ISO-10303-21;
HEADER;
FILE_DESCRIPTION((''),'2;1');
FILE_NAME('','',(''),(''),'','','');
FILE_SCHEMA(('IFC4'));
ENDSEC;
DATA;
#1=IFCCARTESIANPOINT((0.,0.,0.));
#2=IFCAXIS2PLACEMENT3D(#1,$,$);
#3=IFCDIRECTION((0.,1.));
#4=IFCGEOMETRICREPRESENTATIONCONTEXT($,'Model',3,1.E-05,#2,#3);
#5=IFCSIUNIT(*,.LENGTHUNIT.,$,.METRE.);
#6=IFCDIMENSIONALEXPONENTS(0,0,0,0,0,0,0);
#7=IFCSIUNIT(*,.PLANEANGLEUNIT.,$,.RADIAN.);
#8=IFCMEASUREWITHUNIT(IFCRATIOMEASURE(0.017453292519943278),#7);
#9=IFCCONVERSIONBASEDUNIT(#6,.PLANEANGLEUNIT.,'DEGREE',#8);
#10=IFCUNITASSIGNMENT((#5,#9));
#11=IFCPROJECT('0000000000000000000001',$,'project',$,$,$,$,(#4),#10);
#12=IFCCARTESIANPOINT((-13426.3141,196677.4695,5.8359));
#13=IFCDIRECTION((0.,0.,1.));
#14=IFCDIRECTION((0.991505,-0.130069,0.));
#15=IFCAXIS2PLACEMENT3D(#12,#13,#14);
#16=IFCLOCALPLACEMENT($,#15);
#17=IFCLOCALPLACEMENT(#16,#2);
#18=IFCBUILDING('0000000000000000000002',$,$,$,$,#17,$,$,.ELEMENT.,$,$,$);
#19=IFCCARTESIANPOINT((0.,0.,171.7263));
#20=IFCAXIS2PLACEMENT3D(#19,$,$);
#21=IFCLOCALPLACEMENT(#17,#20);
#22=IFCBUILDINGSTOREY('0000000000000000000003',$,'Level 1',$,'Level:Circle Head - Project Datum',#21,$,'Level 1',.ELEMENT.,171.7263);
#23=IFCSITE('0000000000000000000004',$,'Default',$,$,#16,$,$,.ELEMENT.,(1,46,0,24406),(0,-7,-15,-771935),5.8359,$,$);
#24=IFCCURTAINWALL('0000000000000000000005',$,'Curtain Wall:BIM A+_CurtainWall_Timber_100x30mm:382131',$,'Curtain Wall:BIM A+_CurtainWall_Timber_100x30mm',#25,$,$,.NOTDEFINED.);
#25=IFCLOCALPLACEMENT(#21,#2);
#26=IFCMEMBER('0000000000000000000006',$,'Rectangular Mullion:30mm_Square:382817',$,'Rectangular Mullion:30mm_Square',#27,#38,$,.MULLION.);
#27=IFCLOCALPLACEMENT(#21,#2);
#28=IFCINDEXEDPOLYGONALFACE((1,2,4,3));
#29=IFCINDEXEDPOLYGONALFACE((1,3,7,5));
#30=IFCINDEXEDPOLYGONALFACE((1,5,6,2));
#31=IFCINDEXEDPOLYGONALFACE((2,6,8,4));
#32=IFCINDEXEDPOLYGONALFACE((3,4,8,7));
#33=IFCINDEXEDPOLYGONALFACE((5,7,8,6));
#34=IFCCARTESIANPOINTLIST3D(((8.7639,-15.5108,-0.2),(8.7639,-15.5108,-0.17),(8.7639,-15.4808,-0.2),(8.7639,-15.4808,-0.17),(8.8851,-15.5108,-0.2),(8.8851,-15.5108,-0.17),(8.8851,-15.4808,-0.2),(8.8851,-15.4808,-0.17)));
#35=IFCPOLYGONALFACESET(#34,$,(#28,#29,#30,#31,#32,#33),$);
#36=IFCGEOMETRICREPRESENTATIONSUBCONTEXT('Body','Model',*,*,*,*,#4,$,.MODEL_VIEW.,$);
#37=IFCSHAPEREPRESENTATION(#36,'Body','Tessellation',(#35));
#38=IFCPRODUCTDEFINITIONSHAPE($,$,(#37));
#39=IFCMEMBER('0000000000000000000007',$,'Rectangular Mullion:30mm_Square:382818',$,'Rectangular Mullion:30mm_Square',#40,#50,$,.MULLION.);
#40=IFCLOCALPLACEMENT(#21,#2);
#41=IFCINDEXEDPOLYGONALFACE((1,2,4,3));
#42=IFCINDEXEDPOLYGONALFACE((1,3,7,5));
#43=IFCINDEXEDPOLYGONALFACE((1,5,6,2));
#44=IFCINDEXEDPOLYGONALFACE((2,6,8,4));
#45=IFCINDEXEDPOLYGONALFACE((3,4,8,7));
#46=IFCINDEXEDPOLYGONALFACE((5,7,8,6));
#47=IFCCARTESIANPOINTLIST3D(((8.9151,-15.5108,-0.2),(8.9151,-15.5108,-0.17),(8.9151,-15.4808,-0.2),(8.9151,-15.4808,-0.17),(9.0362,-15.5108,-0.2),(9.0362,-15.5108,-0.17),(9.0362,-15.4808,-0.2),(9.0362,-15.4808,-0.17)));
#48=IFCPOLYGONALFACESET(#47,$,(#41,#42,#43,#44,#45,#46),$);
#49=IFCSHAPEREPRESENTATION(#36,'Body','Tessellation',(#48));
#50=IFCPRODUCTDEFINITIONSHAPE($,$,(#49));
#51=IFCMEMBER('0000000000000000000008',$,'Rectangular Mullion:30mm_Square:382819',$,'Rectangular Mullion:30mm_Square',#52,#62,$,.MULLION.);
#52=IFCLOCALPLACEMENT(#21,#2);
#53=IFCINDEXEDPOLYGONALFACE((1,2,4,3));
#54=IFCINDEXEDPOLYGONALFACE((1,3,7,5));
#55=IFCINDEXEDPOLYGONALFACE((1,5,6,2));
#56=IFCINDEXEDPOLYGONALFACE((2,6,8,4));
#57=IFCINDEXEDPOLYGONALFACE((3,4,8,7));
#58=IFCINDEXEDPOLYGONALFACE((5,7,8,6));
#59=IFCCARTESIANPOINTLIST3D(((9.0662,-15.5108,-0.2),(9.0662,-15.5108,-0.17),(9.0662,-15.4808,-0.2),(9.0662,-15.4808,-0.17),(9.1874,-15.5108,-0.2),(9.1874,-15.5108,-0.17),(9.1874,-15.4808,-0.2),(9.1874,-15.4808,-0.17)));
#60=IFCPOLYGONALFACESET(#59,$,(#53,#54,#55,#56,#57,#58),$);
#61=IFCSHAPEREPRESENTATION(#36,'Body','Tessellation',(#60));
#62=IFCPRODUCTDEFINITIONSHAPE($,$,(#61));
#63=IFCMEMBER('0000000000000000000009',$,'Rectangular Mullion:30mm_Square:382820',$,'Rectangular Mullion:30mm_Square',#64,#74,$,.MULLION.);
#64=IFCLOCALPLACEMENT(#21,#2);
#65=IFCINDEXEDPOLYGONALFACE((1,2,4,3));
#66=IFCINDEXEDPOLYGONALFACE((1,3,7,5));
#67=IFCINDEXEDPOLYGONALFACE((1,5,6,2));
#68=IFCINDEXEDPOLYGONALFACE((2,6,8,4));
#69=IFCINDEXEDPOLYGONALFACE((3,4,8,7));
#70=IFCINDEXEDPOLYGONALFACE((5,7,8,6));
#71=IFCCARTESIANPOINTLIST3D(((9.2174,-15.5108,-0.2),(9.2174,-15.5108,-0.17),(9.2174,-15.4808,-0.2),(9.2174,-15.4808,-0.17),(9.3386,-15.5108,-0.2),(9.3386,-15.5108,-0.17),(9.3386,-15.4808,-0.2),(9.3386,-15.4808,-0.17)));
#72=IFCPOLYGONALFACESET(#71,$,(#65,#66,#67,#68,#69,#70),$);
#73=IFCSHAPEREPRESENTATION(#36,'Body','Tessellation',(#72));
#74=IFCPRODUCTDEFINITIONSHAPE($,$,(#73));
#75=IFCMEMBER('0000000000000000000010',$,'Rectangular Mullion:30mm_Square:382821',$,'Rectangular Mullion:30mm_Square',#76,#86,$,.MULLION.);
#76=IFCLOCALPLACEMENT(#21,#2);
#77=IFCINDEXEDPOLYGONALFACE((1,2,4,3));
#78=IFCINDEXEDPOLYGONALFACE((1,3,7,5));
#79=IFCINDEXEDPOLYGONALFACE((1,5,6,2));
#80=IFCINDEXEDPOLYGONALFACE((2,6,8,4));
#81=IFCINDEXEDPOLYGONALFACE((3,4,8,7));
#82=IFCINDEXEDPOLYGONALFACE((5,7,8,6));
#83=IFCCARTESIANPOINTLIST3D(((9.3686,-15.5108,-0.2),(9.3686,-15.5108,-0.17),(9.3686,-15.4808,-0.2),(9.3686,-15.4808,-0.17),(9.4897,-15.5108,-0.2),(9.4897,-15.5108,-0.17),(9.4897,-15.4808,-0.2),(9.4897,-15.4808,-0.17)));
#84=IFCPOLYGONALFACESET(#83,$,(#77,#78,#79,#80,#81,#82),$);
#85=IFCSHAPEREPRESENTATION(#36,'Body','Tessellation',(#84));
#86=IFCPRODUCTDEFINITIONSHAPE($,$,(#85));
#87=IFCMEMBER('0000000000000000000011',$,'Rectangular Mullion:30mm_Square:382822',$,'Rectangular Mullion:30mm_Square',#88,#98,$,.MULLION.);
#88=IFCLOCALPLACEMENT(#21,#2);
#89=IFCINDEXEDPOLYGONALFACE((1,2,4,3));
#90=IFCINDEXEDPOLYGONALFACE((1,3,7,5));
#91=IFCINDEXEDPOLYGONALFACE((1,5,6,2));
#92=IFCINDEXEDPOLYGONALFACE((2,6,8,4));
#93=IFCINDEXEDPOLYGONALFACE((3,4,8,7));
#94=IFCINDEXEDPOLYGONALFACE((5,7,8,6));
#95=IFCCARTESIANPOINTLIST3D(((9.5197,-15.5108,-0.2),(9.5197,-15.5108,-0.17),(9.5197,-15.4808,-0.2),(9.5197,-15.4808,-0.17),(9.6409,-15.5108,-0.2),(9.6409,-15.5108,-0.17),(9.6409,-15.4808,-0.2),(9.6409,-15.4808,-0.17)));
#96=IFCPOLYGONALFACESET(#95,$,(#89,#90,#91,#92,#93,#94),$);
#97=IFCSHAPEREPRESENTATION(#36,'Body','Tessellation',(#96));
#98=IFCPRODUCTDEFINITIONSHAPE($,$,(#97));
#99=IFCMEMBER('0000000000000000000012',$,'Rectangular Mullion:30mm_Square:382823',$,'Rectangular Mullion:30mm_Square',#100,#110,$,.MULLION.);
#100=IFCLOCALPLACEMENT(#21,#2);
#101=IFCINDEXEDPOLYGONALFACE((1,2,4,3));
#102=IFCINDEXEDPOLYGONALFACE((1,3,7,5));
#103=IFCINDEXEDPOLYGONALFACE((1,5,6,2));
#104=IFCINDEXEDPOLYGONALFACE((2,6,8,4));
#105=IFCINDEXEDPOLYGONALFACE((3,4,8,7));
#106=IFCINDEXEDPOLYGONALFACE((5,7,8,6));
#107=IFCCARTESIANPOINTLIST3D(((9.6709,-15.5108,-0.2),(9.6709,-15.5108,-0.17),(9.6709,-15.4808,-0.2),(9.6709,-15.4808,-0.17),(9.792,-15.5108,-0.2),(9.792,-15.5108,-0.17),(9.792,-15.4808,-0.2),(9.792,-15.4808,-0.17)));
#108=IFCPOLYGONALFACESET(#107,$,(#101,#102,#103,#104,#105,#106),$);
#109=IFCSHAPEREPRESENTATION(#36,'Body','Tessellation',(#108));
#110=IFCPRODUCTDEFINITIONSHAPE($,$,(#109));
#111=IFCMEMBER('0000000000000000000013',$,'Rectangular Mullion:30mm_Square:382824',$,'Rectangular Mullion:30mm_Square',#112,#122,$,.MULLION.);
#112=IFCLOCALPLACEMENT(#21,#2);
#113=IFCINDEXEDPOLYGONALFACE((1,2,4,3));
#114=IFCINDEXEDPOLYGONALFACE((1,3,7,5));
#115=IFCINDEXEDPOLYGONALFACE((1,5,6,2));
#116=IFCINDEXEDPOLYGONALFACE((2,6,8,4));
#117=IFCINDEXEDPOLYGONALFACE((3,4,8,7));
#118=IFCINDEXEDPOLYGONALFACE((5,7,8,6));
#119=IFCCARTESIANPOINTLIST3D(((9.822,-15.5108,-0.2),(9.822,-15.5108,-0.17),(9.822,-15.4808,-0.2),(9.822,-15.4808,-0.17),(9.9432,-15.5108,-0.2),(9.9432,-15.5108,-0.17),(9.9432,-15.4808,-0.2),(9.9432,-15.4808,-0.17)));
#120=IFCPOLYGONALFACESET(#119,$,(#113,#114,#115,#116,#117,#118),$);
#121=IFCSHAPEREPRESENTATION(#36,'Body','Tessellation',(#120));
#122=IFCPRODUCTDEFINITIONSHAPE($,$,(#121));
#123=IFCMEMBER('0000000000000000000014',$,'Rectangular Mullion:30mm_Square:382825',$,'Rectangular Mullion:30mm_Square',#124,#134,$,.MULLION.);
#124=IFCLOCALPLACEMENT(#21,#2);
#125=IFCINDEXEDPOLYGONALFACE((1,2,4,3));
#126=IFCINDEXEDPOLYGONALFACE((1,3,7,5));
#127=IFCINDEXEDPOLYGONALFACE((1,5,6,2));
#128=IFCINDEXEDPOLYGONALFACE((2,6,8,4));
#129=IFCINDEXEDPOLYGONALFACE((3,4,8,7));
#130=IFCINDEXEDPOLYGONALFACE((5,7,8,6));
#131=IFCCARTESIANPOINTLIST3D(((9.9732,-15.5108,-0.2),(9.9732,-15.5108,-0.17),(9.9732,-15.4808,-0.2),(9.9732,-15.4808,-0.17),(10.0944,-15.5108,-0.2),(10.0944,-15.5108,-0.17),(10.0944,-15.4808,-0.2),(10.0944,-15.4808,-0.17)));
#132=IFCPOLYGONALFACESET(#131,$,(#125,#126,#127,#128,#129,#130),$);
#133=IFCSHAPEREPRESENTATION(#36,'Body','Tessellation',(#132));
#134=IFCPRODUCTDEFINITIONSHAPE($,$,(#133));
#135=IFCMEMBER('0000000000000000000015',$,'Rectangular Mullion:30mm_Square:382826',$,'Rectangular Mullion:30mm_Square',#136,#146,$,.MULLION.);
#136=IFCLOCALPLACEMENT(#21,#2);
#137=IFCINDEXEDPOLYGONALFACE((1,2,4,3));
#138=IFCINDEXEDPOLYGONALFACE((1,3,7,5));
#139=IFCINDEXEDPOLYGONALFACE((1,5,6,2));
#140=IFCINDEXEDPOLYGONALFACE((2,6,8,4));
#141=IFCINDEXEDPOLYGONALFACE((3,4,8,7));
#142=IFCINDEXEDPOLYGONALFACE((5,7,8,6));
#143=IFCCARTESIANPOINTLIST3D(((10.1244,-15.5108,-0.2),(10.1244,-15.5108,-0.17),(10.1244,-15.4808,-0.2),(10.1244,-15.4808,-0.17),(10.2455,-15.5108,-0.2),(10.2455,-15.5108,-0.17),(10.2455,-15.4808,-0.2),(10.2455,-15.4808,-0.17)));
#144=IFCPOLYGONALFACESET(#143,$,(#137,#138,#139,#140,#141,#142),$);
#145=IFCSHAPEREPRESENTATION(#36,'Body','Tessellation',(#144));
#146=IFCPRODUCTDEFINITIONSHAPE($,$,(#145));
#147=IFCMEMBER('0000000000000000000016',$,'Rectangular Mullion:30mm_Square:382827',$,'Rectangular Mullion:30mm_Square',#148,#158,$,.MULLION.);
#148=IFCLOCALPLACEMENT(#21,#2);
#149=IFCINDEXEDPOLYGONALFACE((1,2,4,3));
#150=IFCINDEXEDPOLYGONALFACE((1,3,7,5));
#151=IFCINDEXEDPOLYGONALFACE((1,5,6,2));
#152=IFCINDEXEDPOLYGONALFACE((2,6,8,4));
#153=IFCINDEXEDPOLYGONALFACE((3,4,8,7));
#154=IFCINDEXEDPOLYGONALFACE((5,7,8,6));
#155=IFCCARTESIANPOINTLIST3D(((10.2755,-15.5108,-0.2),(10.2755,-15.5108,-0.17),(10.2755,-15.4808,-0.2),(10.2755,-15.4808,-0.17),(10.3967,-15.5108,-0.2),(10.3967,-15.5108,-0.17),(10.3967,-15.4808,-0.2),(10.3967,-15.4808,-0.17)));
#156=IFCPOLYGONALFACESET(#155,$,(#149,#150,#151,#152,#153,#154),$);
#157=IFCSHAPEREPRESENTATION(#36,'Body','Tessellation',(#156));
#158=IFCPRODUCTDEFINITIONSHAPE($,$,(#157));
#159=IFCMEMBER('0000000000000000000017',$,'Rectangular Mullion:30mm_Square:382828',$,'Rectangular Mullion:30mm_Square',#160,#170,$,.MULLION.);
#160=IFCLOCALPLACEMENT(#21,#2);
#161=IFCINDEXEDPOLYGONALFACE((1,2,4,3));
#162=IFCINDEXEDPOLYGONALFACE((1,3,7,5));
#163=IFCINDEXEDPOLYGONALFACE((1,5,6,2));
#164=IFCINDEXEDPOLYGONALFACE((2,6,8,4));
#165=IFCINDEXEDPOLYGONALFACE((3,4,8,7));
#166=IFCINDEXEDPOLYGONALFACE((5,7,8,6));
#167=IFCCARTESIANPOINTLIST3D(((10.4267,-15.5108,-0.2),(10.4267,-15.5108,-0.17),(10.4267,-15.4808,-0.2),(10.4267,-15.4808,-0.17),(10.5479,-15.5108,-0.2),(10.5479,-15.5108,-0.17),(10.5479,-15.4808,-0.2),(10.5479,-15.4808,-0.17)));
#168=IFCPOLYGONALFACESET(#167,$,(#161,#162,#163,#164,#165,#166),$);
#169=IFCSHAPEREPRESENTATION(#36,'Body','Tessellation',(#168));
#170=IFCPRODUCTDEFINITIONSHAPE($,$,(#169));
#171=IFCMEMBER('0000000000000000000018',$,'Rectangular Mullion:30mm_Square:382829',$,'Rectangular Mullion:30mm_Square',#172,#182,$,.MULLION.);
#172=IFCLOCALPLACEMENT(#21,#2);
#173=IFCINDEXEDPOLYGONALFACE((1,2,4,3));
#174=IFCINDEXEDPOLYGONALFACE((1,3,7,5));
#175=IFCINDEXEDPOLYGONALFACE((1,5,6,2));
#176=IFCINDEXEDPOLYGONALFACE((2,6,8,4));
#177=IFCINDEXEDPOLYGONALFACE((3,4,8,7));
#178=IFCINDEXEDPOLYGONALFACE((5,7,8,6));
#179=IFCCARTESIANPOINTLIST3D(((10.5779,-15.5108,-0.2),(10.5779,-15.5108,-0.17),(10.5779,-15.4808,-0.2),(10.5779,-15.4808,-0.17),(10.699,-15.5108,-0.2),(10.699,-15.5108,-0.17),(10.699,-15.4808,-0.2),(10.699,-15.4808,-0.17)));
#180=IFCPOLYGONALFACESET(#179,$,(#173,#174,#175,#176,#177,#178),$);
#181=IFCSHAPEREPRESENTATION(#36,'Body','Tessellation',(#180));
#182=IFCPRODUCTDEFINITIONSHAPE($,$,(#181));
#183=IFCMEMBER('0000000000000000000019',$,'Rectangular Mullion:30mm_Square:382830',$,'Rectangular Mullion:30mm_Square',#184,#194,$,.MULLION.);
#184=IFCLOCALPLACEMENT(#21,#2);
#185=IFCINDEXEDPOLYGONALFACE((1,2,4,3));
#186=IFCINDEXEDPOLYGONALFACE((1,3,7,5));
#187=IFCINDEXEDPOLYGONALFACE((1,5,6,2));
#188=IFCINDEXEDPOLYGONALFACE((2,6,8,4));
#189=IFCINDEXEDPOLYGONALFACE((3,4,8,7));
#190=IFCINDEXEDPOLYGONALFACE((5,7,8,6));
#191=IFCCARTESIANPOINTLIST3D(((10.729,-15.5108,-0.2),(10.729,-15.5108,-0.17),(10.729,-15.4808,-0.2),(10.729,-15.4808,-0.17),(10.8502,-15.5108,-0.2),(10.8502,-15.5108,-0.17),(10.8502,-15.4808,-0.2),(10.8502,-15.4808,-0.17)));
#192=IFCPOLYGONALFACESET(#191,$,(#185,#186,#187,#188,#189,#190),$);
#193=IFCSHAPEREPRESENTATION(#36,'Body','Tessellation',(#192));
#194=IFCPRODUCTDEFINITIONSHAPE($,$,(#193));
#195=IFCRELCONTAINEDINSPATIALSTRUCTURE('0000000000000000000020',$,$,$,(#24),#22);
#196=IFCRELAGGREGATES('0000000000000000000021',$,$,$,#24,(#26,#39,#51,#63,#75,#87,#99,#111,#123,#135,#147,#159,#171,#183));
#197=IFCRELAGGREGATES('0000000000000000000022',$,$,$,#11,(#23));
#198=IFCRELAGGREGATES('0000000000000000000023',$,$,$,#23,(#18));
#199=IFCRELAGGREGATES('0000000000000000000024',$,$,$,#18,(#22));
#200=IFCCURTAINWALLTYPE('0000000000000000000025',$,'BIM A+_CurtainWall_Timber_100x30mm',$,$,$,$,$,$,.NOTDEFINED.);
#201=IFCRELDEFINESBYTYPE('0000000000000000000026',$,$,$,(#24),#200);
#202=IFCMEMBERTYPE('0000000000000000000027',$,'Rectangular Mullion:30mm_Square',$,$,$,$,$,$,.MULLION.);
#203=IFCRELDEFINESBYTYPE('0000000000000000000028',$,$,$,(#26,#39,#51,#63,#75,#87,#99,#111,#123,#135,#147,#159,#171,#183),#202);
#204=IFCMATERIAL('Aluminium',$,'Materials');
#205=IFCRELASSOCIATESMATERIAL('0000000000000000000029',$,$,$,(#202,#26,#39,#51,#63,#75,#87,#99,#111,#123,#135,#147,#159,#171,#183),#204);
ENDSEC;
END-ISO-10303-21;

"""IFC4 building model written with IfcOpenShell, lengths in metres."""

from ifc_helpers import new_model, entity, si_unit, converted_unit, direction, frame, origin, place, context, subcontext, project, spatial, indexed_curve, outline, extrude, source, transform, mapped, material, type_object, type_shapes, element, aggregate, save


model = new_model("IFC4")

# Units and contexts
model_context = context("Model", 3, precision=1e-05, world=origin(), true_north=direction((0.0, 1.0)))
body_context = subcontext(model_context, "Body", "Model", "MODEL_VIEW")
ifc_project = project(units=[si_unit("LENGTHUNIT", "METRE"), converted_unit("PLANEANGLEUNIT", "DEGREE", entity("IfcRatioMeasure", 0.017453292519943278), si_unit("PLANEANGLEUNIT", "RADIAN"), dimensions=[0, 0, 0, 0, 0, 0, 0])], contexts=[model_context])

# Site, building, storey
site_placement = place(None, frame((-13426.3141, 196677.4695, 5.8359), z_axis=(0.0, 0.0, 1.0), x_axis=(0.991505, -0.130069, 0.0)))
site = spatial("IfcSite", under=ifc_project, at=site_placement, Name="Default", CompositionType="ELEMENT", RefLatitude=(1, 46, 0, 24406), RefLongitude=(0, -7, -15, -771935), RefElevation=5.8359)
building_placement = place(site_placement, origin())
building = spatial("IfcBuilding", under=site, at=building_placement, CompositionType="ELEMENT")
storey_placement = place(building_placement, frame((0.0, 0.0, 171.7263)))
storey = spatial("IfcBuildingStorey", under=building, at=storey_placement, Name="Level 1", ObjectType="Level:Circle Head - Project Datum", LongName="Level 1", CompositionType="ELEMENT", Elevation=171.7263)

# Curtain wall, members
curtain_wall_type = type_object("IfcCurtainWallType", Name="BIM A+_CurtainWall_Timber_100x30mm", PredefinedType="NOTDEFINED")
curtain_wall_placement = place(storey_placement, frame((0.0, 0.0, -171.7263)))
curtain_wall = element("IfcCurtainWall", 1, at=curtain_wall_placement, inside=storey, type_object=curtain_wall_type, Name="Curtain Wall:BIM A+_CurtainWall_Timber_100x30mm:382131", ObjectType="Curtain Wall:BIM A+_CurtainWall_Timber_100x30mm", PredefinedType="NOTDEFINED")
ifc_material_1 = material(Name="Aluminium", Category="Materials")
member_type = type_object("IfcMemberType", Name="Rectangular Mullion:30mm_Square", PredefinedType="MULLION", material=ifc_material_1)
shared_shape_1 = source(origin(), body_context, "Body", "SweptSolid", [
    extrude(outline(indexed_curve([(-0.015, -0.015), (0.015, -0.015), (0.015, 0.015), (-0.015, 0.015), (-0.015, -0.015)], self_intersect=False)), frame((-0.015, 0.0, -0.1212), z_axis=(0.0, 0.0, 1.0), x_axis=(0.0, -1.0, 0.0)), (0.0, 0.0, 1.0), 0.1212),
])
type_shapes(member_type, [shared_shape_1])
member_1_placement = place(curtain_wall_placement, frame((8.7639, -15.4958, 171.5263), z_axis=(-1.0, 0.0, 0.0), x_axis=(0.0, 0.0, -1.0)))
member_1 = element("IfcMember", 2, at=member_1_placement, type_object=member_type, material=ifc_material_1, Name="Rectangular Mullion:30mm_Square:382817", ObjectType="Rectangular Mullion:30mm_Square", PredefinedType="MULLION", context=body_context, shape_type="MappedRepresentation", body=[
    mapped(shared_shape_1, transform((0.0, 0.0, 0.0), scale=1.0)),
])
member_2_placement = place(curtain_wall_placement, frame((8.9151, -15.4958, 171.5263), z_axis=(-1.0, 0.0, 0.0), x_axis=(0.0, 0.0, -1.0)))
member_2 = element("IfcMember", 3, at=member_2_placement, type_object=member_type, material=ifc_material_1, Name="Rectangular Mullion:30mm_Square:382818", ObjectType="Rectangular Mullion:30mm_Square", PredefinedType="MULLION", context=body_context, shape_type="MappedRepresentation", body=[
    mapped(shared_shape_1, transform((0.0, 0.0, 0.0), scale=1.0)),
])
member_3_placement = place(curtain_wall_placement, frame((9.0662, -15.4958, 171.5263), z_axis=(-1.0, 0.0, 0.0), x_axis=(0.0, 0.0, -1.0)))
member_3 = element("IfcMember", 4, at=member_3_placement, type_object=member_type, material=ifc_material_1, Name="Rectangular Mullion:30mm_Square:382819", ObjectType="Rectangular Mullion:30mm_Square", PredefinedType="MULLION", context=body_context, shape_type="MappedRepresentation", body=[
    mapped(shared_shape_1, transform((0.0, 0.0, 0.0), scale=1.0)),
])
member_4_placement = place(curtain_wall_placement, frame((9.2174, -15.4958, 171.5263), z_axis=(-1.0, 0.0, 0.0), x_axis=(0.0, 0.0, -1.0)))
member_4 = element("IfcMember", 5, at=member_4_placement, type_object=member_type, material=ifc_material_1, Name="Rectangular Mullion:30mm_Square:382820", ObjectType="Rectangular Mullion:30mm_Square", PredefinedType="MULLION", context=body_context, shape_type="MappedRepresentation", body=[
    mapped(shared_shape_1, transform((0.0, 0.0, 0.0), scale=1.0)),
])
member_5_placement = place(curtain_wall_placement, frame((9.3686, -15.4958, 171.5263), z_axis=(-1.0, 0.0, 0.0), x_axis=(0.0, 0.0, -1.0)))
member_5 = element("IfcMember", 6, at=member_5_placement, type_object=member_type, material=ifc_material_1, Name="Rectangular Mullion:30mm_Square:382821", ObjectType="Rectangular Mullion:30mm_Square", PredefinedType="MULLION", context=body_context, shape_type="MappedRepresentation", body=[
    mapped(shared_shape_1, transform((0.0, 0.0, 0.0), scale=1.0)),
])
member_6_placement = place(curtain_wall_placement, frame((9.5197, -15.4958, 171.5263), z_axis=(-1.0, 0.0, 0.0), x_axis=(0.0, 0.0, -1.0)))
member_6 = element("IfcMember", 7, at=member_6_placement, type_object=member_type, material=ifc_material_1, Name="Rectangular Mullion:30mm_Square:382822", ObjectType="Rectangular Mullion:30mm_Square", PredefinedType="MULLION", context=body_context, shape_type="MappedRepresentation", body=[
    mapped(shared_shape_1, transform((0.0, 0.0, 0.0), scale=1.0)),
])
member_7_placement = place(curtain_wall_placement, frame((9.6709, -15.4958, 171.5263), z_axis=(-1.0, 0.0, 0.0), x_axis=(0.0, 0.0, -1.0)))
member_7 = element("IfcMember", 8, at=member_7_placement, type_object=member_type, material=ifc_material_1, Name="Rectangular Mullion:30mm_Square:382823", ObjectType="Rectangular Mullion:30mm_Square", PredefinedType="MULLION", context=body_context, shape_type="MappedRepresentation", body=[
    mapped(shared_shape_1, transform((0.0, 0.0, 0.0), scale=1.0)),
])
member_8_placement = place(curtain_wall_placement, frame((9.822, -15.4958, 171.5263), z_axis=(-1.0, 0.0, 0.0), x_axis=(0.0, 0.0, -1.0)))
member_8 = element("IfcMember", 9, at=member_8_placement, type_object=member_type, material=ifc_material_1, Name="Rectangular Mullion:30mm_Square:382824", ObjectType="Rectangular Mullion:30mm_Square", PredefinedType="MULLION", context=body_context, shape_type="MappedRepresentation", body=[
    mapped(shared_shape_1, transform((0.0, 0.0, 0.0), scale=1.0)),
])
member_9_placement = place(curtain_wall_placement, frame((9.9732, -15.4958, 171.5263), z_axis=(-1.0, 0.0, 0.0), x_axis=(0.0, 0.0, -1.0)))
member_9 = element("IfcMember", 10, at=member_9_placement, type_object=member_type, material=ifc_material_1, Name="Rectangular Mullion:30mm_Square:382825", ObjectType="Rectangular Mullion:30mm_Square", PredefinedType="MULLION", context=body_context, shape_type="MappedRepresentation", body=[
    mapped(shared_shape_1, transform((0.0, 0.0, 0.0), scale=1.0)),
])
member_10_placement = place(curtain_wall_placement, frame((10.1244, -15.4958, 171.5263), z_axis=(-1.0, 0.0, 0.0), x_axis=(0.0, 0.0, -1.0)))
member_10 = element("IfcMember", 11, at=member_10_placement, type_object=member_type, material=ifc_material_1, Name="Rectangular Mullion:30mm_Square:382826", ObjectType="Rectangular Mullion:30mm_Square", PredefinedType="MULLION", context=body_context, shape_type="MappedRepresentation", body=[
    mapped(shared_shape_1, transform((0.0, 0.0, 0.0), scale=1.0)),
])
member_11_placement = place(curtain_wall_placement, frame((10.2755, -15.4958, 171.5263), z_axis=(-1.0, 0.0, 0.0), x_axis=(0.0, 0.0, -1.0)))
member_11 = element("IfcMember", 12, at=member_11_placement, type_object=member_type, material=ifc_material_1, Name="Rectangular Mullion:30mm_Square:382827", ObjectType="Rectangular Mullion:30mm_Square", PredefinedType="MULLION", context=body_context, shape_type="MappedRepresentation", body=[
    mapped(shared_shape_1, transform((0.0, 0.0, 0.0), scale=1.0)),
])
member_12_placement = place(curtain_wall_placement, frame((10.4267, -15.4958, 171.5263), z_axis=(-1.0, 0.0, 0.0), x_axis=(0.0, 0.0, -1.0)))
member_12 = element("IfcMember", 13, at=member_12_placement, type_object=member_type, material=ifc_material_1, Name="Rectangular Mullion:30mm_Square:382828", ObjectType="Rectangular Mullion:30mm_Square", PredefinedType="MULLION", context=body_context, shape_type="MappedRepresentation", body=[
    mapped(shared_shape_1, transform((0.0, 0.0, 0.0), scale=1.0)),
])
member_13_placement = place(curtain_wall_placement, frame((10.5779, -15.4958, 171.5263), z_axis=(-1.0, 0.0, 0.0), x_axis=(0.0, 0.0, -1.0)))
member_13 = element("IfcMember", 14, at=member_13_placement, type_object=member_type, material=ifc_material_1, Name="Rectangular Mullion:30mm_Square:382829", ObjectType="Rectangular Mullion:30mm_Square", PredefinedType="MULLION", context=body_context, shape_type="MappedRepresentation", body=[
    mapped(shared_shape_1, transform((0.0, 0.0, 0.0), scale=1.0)),
])
member_14_placement = place(curtain_wall_placement, frame((10.729, -15.4958, 171.5263), z_axis=(-1.0, 0.0, 0.0), x_axis=(0.0, 0.0, -1.0)))
member_14 = element("IfcMember", 15, at=member_14_placement, type_object=member_type, material=ifc_material_1, Name="Rectangular Mullion:30mm_Square:382830", ObjectType="Rectangular Mullion:30mm_Square", PredefinedType="MULLION", context=body_context, shape_type="MappedRepresentation", body=[
    mapped(shared_shape_1, transform((0.0, 0.0, 0.0), scale=1.0)),
])
aggregate(curtain_wall, [member_1, member_2, member_3, member_4, member_5, member_6, member_7, member_8, member_9, member_10, member_11, member_12, member_13, member_14])

save(model, "model.ifc")
